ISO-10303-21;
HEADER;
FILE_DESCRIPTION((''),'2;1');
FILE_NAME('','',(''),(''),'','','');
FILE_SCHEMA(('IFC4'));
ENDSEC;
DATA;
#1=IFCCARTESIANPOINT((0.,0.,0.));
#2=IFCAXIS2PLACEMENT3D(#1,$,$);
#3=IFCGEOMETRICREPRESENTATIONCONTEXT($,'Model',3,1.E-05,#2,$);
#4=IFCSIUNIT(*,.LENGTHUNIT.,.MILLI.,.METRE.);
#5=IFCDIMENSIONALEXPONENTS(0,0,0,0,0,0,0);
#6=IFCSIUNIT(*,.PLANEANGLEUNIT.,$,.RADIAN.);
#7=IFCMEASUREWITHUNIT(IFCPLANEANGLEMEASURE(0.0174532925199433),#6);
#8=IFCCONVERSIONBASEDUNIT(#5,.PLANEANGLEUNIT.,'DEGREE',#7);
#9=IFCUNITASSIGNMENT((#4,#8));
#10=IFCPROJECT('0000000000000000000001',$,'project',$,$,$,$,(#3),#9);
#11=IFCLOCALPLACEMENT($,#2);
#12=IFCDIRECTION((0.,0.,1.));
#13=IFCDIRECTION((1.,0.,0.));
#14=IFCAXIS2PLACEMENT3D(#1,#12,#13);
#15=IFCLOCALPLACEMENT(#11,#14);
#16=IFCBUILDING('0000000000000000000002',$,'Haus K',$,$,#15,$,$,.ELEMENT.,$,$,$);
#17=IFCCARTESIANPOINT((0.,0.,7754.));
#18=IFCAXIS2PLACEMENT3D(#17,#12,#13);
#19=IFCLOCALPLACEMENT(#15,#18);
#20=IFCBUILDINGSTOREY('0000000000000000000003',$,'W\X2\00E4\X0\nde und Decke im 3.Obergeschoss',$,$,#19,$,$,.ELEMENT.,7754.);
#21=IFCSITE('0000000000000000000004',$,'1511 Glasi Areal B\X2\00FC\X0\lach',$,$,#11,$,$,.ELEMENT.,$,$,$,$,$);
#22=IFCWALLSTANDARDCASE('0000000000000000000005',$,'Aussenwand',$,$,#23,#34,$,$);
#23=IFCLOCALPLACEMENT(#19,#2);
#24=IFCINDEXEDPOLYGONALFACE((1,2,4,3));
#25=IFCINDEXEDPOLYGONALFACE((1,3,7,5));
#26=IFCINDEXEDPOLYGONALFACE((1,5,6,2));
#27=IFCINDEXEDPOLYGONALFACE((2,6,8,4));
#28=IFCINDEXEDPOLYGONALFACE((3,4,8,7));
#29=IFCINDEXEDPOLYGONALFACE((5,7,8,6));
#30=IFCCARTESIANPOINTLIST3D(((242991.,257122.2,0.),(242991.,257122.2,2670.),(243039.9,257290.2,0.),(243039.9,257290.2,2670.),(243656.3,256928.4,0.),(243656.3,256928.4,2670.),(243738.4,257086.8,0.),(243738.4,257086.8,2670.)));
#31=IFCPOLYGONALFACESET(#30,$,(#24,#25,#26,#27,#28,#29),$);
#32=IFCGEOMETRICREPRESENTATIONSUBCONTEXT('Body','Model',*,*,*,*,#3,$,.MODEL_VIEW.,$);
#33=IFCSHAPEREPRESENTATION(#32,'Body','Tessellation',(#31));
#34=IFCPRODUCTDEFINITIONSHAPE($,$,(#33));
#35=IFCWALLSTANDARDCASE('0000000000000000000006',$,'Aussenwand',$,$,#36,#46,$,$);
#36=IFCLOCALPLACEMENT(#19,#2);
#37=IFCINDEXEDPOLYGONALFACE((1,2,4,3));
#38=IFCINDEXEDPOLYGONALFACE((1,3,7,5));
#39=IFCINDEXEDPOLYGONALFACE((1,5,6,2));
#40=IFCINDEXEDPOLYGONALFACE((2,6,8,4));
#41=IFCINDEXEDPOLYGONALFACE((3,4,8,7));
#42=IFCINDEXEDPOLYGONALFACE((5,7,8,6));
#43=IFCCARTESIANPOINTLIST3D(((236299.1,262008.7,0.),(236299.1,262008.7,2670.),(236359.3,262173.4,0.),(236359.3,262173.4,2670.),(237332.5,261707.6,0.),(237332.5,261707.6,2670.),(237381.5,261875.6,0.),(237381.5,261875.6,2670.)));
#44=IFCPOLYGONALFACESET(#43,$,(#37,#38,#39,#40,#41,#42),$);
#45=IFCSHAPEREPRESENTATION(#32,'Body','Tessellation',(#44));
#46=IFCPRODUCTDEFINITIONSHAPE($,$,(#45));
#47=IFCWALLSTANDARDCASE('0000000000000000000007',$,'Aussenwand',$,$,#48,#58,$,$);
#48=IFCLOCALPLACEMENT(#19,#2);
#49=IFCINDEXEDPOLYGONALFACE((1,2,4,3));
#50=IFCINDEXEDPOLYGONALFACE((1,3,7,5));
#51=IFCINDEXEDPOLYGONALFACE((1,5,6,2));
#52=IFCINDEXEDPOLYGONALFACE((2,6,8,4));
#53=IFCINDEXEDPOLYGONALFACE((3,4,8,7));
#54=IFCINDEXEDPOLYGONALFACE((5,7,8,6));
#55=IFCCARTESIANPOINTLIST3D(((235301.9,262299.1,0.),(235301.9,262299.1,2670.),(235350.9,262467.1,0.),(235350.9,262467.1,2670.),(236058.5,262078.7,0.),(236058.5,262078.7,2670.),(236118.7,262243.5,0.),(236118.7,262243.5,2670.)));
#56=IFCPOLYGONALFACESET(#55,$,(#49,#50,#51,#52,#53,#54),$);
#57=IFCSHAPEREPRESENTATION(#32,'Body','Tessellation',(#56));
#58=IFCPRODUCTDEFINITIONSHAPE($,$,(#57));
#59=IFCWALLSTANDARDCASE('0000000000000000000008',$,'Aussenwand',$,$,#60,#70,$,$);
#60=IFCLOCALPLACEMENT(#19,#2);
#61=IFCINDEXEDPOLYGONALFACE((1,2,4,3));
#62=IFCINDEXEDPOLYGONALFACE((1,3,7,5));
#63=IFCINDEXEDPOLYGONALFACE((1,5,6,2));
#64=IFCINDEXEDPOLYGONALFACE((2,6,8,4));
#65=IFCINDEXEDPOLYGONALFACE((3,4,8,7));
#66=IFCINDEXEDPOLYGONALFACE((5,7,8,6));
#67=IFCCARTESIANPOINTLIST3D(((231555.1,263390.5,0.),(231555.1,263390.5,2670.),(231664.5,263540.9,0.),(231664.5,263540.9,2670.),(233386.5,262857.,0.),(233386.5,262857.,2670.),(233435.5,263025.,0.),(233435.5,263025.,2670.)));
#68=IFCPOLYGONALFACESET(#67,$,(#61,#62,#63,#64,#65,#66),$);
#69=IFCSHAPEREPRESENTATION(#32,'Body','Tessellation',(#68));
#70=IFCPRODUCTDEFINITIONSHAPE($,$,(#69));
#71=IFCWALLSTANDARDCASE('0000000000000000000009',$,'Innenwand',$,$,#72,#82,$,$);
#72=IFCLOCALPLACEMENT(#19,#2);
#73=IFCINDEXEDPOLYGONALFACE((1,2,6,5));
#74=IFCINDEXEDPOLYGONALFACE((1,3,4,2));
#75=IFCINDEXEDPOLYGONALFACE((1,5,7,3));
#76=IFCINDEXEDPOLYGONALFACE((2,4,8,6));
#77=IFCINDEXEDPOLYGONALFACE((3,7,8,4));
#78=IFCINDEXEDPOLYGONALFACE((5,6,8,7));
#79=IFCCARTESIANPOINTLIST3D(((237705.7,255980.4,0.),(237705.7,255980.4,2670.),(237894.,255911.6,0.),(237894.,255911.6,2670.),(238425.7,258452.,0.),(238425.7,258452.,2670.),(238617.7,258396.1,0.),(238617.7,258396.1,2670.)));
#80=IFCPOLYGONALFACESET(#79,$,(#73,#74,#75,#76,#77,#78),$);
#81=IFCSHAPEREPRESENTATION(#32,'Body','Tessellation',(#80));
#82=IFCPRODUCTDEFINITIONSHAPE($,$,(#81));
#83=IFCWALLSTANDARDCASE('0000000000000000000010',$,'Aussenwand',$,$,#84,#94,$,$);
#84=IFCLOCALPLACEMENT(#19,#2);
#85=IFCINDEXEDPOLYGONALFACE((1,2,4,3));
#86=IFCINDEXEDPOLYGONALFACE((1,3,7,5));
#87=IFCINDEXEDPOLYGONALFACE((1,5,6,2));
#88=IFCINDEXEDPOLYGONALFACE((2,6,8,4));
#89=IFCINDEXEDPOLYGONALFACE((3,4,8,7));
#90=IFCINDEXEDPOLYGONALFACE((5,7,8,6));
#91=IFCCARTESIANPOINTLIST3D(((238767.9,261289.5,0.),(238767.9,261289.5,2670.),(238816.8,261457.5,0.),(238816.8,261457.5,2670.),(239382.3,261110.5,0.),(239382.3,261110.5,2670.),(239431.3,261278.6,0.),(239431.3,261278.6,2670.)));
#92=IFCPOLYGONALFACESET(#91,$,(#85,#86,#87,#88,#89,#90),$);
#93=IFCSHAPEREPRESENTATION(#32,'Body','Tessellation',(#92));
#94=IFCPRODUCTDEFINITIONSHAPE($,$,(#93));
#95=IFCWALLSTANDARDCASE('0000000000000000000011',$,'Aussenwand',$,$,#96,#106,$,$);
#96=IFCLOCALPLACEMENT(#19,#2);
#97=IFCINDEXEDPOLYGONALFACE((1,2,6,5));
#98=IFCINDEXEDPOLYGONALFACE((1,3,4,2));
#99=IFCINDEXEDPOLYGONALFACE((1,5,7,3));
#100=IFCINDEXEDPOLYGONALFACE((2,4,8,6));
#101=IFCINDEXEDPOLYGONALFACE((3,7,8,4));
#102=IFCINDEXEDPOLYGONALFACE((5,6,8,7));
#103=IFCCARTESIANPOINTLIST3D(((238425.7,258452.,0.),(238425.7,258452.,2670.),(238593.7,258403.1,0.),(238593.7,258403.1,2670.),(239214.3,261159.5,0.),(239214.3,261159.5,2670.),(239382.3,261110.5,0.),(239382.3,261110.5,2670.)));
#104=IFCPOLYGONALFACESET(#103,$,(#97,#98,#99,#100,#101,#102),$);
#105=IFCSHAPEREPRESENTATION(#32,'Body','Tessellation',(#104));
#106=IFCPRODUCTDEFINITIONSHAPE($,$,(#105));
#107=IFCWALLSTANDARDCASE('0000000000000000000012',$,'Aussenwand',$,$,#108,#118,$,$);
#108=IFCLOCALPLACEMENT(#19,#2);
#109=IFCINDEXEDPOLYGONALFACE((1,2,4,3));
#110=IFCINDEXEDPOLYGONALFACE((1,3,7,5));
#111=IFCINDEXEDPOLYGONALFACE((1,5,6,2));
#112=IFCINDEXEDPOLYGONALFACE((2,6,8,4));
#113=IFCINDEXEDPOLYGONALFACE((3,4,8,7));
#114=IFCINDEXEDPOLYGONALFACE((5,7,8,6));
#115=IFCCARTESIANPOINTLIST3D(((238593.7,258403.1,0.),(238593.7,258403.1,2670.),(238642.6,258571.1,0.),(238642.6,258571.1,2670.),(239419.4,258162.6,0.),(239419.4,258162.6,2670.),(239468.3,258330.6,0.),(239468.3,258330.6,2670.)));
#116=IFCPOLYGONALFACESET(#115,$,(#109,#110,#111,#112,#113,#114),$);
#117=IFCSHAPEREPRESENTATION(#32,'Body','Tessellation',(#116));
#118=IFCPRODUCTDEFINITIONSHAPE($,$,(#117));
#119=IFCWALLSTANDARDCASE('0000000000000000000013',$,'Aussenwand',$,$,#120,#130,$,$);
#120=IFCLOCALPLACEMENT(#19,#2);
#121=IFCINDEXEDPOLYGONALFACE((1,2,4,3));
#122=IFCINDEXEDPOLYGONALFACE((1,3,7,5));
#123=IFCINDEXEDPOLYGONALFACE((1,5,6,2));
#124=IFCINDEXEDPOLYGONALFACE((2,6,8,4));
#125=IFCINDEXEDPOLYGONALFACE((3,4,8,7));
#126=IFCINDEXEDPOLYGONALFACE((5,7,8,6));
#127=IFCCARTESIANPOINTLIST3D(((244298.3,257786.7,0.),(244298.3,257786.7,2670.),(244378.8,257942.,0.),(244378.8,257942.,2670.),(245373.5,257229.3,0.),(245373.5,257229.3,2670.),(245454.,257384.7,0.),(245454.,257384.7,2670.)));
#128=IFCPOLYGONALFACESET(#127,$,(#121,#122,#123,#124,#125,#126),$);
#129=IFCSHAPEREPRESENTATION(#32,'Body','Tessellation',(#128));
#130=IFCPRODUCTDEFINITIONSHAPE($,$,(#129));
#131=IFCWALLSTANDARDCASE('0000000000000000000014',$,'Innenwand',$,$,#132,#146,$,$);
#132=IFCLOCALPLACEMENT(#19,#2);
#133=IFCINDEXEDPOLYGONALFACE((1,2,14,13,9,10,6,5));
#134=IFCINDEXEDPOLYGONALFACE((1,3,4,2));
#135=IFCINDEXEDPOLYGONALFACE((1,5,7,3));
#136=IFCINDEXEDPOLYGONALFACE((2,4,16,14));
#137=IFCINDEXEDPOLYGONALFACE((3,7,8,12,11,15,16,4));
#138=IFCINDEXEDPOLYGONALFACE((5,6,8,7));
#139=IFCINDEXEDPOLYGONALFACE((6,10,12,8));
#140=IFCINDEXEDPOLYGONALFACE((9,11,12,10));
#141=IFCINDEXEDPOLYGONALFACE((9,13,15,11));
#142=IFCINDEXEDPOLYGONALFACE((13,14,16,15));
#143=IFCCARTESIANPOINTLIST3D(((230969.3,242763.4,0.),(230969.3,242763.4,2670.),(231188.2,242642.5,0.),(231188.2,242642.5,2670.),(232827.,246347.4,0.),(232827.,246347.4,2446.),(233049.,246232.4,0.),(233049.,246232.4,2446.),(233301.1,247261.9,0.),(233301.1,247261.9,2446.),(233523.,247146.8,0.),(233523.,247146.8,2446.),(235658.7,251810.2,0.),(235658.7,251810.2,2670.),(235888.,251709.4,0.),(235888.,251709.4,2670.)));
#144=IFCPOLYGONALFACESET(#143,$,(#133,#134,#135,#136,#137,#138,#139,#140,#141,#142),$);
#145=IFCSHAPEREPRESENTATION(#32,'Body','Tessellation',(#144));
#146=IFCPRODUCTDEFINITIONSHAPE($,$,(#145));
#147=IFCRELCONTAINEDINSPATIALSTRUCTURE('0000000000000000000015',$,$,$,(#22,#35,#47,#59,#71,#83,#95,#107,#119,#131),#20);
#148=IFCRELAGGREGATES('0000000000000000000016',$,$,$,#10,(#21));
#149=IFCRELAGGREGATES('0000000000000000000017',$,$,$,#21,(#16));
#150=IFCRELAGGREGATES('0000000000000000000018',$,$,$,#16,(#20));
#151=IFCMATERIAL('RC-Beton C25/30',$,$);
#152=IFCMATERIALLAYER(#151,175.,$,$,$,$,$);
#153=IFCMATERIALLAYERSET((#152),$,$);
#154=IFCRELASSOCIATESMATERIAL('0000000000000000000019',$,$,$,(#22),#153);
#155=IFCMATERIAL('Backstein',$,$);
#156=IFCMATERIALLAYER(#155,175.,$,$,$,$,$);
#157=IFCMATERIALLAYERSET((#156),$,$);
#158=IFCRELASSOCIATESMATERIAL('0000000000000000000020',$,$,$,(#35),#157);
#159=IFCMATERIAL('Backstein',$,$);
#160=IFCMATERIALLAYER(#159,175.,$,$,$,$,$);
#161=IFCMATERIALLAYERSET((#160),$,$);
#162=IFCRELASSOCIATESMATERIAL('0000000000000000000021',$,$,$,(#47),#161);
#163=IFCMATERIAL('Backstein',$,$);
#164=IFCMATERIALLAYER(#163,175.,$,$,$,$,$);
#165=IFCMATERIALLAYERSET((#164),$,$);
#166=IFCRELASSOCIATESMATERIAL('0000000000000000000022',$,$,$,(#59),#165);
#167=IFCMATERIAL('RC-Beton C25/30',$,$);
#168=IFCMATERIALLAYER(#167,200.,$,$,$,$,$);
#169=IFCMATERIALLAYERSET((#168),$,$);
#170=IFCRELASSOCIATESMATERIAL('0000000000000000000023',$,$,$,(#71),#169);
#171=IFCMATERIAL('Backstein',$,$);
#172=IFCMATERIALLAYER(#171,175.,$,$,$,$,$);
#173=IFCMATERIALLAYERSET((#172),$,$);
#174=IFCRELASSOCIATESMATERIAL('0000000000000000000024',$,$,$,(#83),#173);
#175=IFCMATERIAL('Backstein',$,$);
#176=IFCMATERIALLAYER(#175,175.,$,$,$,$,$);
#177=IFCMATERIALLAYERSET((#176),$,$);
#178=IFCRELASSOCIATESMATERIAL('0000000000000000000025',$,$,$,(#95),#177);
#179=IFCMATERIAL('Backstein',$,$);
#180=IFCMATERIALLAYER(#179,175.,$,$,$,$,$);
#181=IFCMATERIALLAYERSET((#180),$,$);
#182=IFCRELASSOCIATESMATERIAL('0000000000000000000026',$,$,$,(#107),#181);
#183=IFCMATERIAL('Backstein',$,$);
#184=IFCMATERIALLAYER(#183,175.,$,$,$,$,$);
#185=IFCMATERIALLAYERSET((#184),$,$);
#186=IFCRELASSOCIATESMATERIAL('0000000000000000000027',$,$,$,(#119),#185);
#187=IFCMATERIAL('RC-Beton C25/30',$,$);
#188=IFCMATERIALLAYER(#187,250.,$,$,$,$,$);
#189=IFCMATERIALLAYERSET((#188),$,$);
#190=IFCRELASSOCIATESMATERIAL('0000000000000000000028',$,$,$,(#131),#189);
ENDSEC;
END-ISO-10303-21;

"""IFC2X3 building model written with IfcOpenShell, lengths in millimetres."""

from ifc_helpers import new_model, entity, si_unit, converted_unit, frame, frame_2d, origin, origin_with_axes, place, context, subcontext, project, spatial, polyline, rectangle, outline, extrude, material, layer, layer_set, layer_usage, element, save


model = new_model("IFC2X3")

# Units and contexts
model_context = context("Model", 3, precision=1e-05, world=origin())
body_context = subcontext(model_context, "Body", "Model", "MODEL_VIEW")
ifc_project = project(units=[si_unit("LENGTHUNIT", "METRE", prefix="MILLI"), converted_unit("PLANEANGLEUNIT", "DEGREE", entity("IfcPlaneAngleMeasure", 0.0174532925199433), si_unit("PLANEANGLEUNIT", "RADIAN"), dimensions=[0, 0, 0, 0, 0, 0, 0])], contexts=[model_context])

# Site, building, storey
site_placement = place(None, origin())
site = spatial("IfcSite", under=ifc_project, at=site_placement, Name="1511 Glasi Areal Bülach", CompositionType="ELEMENT")
building_placement = place(site_placement, origin_with_axes())
building = spatial("IfcBuilding", under=site, at=building_placement, Name="Haus K", CompositionType="ELEMENT")
storey_placement = place(building_placement, frame((0.0, 0.0, 7754.0), z_axis=(0.0, 0.0, 1.0), x_axis=(1.0, 0.0, 0.0)))
storey = spatial("IfcBuildingStorey", under=building, at=storey_placement, Name="Wände und Decke im 3.Obergeschoss", CompositionType="ELEMENT", Elevation=7754.0)

# Walls
ifc_material_1 = material(Name="RC-Beton C25/30")
ifc_layer_1 = layer(ifc_material_1, 175.0)
ifc_layer_set_1 = layer_set([ifc_layer_1])
ifc_layer_usage_1 = layer_usage(ifc_layer_set_1, "AXIS2", "POSITIVE", 0.0)
wall_1_placement = place(storey_placement, frame((243738.4, 257086.8, 0.0), z_axis=(0.0, 0.0, 1.0), x_axis=(-0.960099, 0.279661, 0.0)))
element("IfcWallStandardCase", 1, at=wall_1_placement, inside=storey, material=ifc_layer_usage_1, Name="Aussenwand", context=body_context, shape_type="SweptSolid", body=[
    extrude(outline(polyline([(0.0, 0.0), (727.5, 0.0), (727.5, 175.0), (34.5, 175.0), (0.0, 0.0)])), origin_with_axes(), (0.0, 0.0, 1.0), 2670.0),
])
ifc_material_2 = material(Name="Backstein")
ifc_layer_2 = layer(ifc_material_2, 175.0)
ifc_layer_set_2 = layer_set([ifc_layer_2])
ifc_layer_usage_2 = layer_usage(ifc_layer_set_2, "AXIS2", "POSITIVE", 0.0)
wall_2_placement = place(storey_placement, frame((237381.5, 261875.6, 0.0), z_axis=(0.0, 0.0, 1.0), x_axis=(-0.960099, 0.279661, 0.0)))
element("IfcWallStandardCase", 2, at=wall_2_placement, inside=storey, material=ifc_layer_usage_2, Name="Aussenwand", context=body_context, shape_type="SweptSolid", body=[
    extrude(outline(polyline([(0.0, 0.0), (1064.7, 0.0), (1076.4, 175.0), (0.0, 175.0), (0.0, 0.0)])), origin_with_axes(), (0.0, 0.0, 1.0), 2670.0),
])
ifc_material_3 = material(Name="Backstein")
ifc_layer_3 = layer(ifc_material_3, 175.0)
ifc_layer_set_3 = layer_set([ifc_layer_3])
ifc_layer_usage_3 = layer_usage(ifc_layer_set_3, "AXIS2", "POSITIVE", 0.0)
wall_3_placement = place(storey_placement, frame((236118.7, 262243.5, 0.0), z_axis=(0.0, 0.0, 1.0), x_axis=(-0.960099, 0.279661, 0.0)))
element("IfcWallStandardCase", 3, at=wall_3_placement, inside=storey, material=ifc_layer_usage_3, Name="Aussenwand", context=body_context, shape_type="SweptSolid", body=[
    extrude(outline(polyline([(0.0, 0.0), (799.8, 0.0), (799.8, 175.0), (11.7, 175.0), (0.0, 0.0)])), origin_with_axes(), (0.0, 0.0, 1.0), 2670.0),
])
ifc_material_4 = material(Name="Backstein")
ifc_layer_4 = layer(ifc_material_4, 175.0)
ifc_layer_set_4 = layer_set([ifc_layer_4])
ifc_layer_usage_4 = layer_usage(ifc_layer_set_4, "AXIS2", "POSITIVE", 0.0)
wall_4_placement = place(storey_placement, frame((233435.5, 263025.0, 0.0), z_axis=(0.0, 0.0, 1.0), x_axis=(-0.960099, 0.279661, 0.0)))
element("IfcWallStandardCase", 4, at=wall_4_placement, inside=storey, material=ifc_layer_usage_4, Name="Aussenwand", context=body_context, shape_type="SweptSolid", body=[
    extrude(outline(polyline([(0.0, 0.0), (1844.5, 0.0), (1907.6, 175.0), (0.0, 175.0), (0.0, 0.0)])), origin_with_axes(), (0.0, 0.0, 1.0), 2670.0),
])
ifc_material_5 = material(Name="RC-Beton C25/30")
ifc_layer_5 = layer(ifc_material_5, 200.0)
ifc_layer_set_5 = layer_set([ifc_layer_5])
ifc_layer_usage_5 = layer_usage(ifc_layer_set_5, "AXIS2", "POSITIVE", 0.0)
wall_5_placement = place(storey_placement, frame((238425.7, 258452.0, 0.0), z_axis=(0.0, 0.0, 1.0), x_axis=(-0.279661, -0.960099, 0.0)))
element("IfcWallStandardCase", 5, at=wall_5_placement, inside=storey, material=ifc_layer_usage_5, Name="Innenwand", context=body_context, shape_type="SweptSolid", body=[
    extrude(outline(polyline([(0.0, 0.0), (2574.3, 0.0), (2587.7, 200.0), (0.0, 200.0), (0.0, 0.0)])), origin_with_axes(), (0.0, 0.0, 1.0), 2670.0),
])
ifc_material_6 = material(Name="Backstein")
ifc_layer_6 = layer(ifc_material_6, 175.0)
ifc_layer_set_6 = layer_set([ifc_layer_6])
ifc_layer_usage_6 = layer_usage(ifc_layer_set_6, "AXIS2", "POSITIVE", 0.0)
wall_6_placement = place(storey_placement, frame((239431.3, 261278.6, 0.0), z_axis=(0.0, 0.0, 1.0), x_axis=(-0.960099, 0.279661, 0.0)))
element("IfcWallStandardCase", 6, at=wall_6_placement, inside=storey, material=ifc_layer_usage_6, Name="Aussenwand", context=body_context, shape_type="SweptSolid", body=[
    extrude(rectangle(XDim=640.0, YDim=175.0, at=frame_2d((320.0, 87.5), x_axis=(1.0, 0.0))), origin_with_axes(), (0.0, 0.0, 1.0), 2670.0),
])
ifc_material_7 = material(Name="Backstein")
ifc_layer_7 = layer(ifc_material_7, 175.0)
ifc_layer_set_7 = layer_set([ifc_layer_7])
ifc_layer_usage_7 = layer_usage(ifc_layer_set_7, "AXIS2", "POSITIVE", 0.0)
wall_7_placement = place(storey_placement, frame((238593.7, 258403.1, 0.0), z_axis=(0.0, 0.0, 1.0), x_axis=(0.279661, 0.960099, 0.0)))
element("IfcWallStandardCase", 7, at=wall_7_placement, inside=storey, material=ifc_layer_usage_7, Name="Aussenwand", context=body_context, shape_type="SweptSolid", body=[
    extrude(rectangle(XDim=2820.0, YDim=175.0, at=frame_2d((1410.0, 87.5), x_axis=(1.0, 0.0))), origin_with_axes(), (0.0, 0.0, 1.0), 2670.0),
])
ifc_material_8 = material(Name="Backstein")
ifc_layer_8 = layer(ifc_material_8, 175.0)
ifc_layer_set_8 = layer_set([ifc_layer_8])
ifc_layer_usage_8 = layer_usage(ifc_layer_set_8, "AXIS2", "POSITIVE", 0.0)
wall_8_placement = place(storey_placement, frame((239468.3, 258330.6, 0.0), z_axis=(0.0, 0.0, 1.0), x_axis=(-0.960099, 0.279661, 0.0)))
element("IfcWallStandardCase", 8, at=wall_8_placement, inside=storey, material=ifc_layer_usage_8, Name="Aussenwand", context=body_context, shape_type="SweptSolid", body=[
    extrude(rectangle(XDim=860.0, YDim=175.0, at=frame_2d((430.0, 87.5), x_axis=(1.0, 0.0))), origin_with_axes(), (0.0, 0.0, 1.0), 2670.0),
])
ifc_material_9 = material(Name="Backstein")
ifc_layer_9 = layer(ifc_material_9, 175.0)
ifc_layer_set_9 = layer_set([ifc_layer_9])
ifc_layer_usage_9 = layer_usage(ifc_layer_set_9, "AXIS2", "POSITIVE", 0.0)
wall_9_placement = place(storey_placement, frame((245454.0, 257384.7, 0.0), z_axis=(0.0, 0.0, 1.0), x_axis=(-0.887815, 0.4602, 0.0)))
element("IfcWallStandardCase", 9, at=wall_9_placement, inside=storey, material=ifc_layer_usage_9, Name="Aussenwand", context=body_context, shape_type="SweptSolid", body=[
    extrude(rectangle(XDim=1211.1, YDim=175.0, at=frame_2d((605.5, 87.5), x_axis=(1.0, 0.0))), origin_with_axes(), (0.0, 0.0, 1.0), 2670.0),
])

# Wall, opening
ifc_material_10 = material(Name="RC-Beton C25/30")
ifc_layer_10 = layer(ifc_material_10, 250.0)
ifc_layer_set_10 = layer_set([ifc_layer_10])
ifc_layer_usage_10 = layer_usage(ifc_layer_set_10, "AXIS2", "POSITIVE", 0.0)
wall_10_placement = place(storey_placement, frame((235658.7, 251810.2, 0.0), z_axis=(0.0, 0.0, 1.0), x_axis=(-0.4602, -0.887815, 0.0)))
wall_10 = element("IfcWallStandardCase", 10, at=wall_10_placement, inside=storey, material=ifc_layer_usage_10, Name="Innenwand", context=body_context, shape_type="SweptSolid", body=[
    extrude(outline(polyline([(0.0, 0.0), (10190.0, 0.0), (10196.6, 250.0), (-16.0, 250.0), (0.0, 0.0)])), origin_with_axes(), (0.0, 0.0, 1.0), 2670.0),
])
opening_placement = place(wall_10_placement, frame((5123.1, 0.0, 0.0), z_axis=(0.0, 1.0, 0.0), x_axis=(0.0, 0.0, 1.0)))
element("IfcOpeningElement", 11, at=opening_placement, cuts=wall_10, ObjectType="Opening", context=body_context, shape_type="SweptSolid", body=[
    extrude(rectangle(XDim=2446.0, YDim=1030.0, at=frame_2d((1223.0, 515.0), x_axis=(1.0, 0.0))), origin_with_axes(), (0.0, 0.0, 1.0), 250.0),
])

save(model, "model.ifc")
